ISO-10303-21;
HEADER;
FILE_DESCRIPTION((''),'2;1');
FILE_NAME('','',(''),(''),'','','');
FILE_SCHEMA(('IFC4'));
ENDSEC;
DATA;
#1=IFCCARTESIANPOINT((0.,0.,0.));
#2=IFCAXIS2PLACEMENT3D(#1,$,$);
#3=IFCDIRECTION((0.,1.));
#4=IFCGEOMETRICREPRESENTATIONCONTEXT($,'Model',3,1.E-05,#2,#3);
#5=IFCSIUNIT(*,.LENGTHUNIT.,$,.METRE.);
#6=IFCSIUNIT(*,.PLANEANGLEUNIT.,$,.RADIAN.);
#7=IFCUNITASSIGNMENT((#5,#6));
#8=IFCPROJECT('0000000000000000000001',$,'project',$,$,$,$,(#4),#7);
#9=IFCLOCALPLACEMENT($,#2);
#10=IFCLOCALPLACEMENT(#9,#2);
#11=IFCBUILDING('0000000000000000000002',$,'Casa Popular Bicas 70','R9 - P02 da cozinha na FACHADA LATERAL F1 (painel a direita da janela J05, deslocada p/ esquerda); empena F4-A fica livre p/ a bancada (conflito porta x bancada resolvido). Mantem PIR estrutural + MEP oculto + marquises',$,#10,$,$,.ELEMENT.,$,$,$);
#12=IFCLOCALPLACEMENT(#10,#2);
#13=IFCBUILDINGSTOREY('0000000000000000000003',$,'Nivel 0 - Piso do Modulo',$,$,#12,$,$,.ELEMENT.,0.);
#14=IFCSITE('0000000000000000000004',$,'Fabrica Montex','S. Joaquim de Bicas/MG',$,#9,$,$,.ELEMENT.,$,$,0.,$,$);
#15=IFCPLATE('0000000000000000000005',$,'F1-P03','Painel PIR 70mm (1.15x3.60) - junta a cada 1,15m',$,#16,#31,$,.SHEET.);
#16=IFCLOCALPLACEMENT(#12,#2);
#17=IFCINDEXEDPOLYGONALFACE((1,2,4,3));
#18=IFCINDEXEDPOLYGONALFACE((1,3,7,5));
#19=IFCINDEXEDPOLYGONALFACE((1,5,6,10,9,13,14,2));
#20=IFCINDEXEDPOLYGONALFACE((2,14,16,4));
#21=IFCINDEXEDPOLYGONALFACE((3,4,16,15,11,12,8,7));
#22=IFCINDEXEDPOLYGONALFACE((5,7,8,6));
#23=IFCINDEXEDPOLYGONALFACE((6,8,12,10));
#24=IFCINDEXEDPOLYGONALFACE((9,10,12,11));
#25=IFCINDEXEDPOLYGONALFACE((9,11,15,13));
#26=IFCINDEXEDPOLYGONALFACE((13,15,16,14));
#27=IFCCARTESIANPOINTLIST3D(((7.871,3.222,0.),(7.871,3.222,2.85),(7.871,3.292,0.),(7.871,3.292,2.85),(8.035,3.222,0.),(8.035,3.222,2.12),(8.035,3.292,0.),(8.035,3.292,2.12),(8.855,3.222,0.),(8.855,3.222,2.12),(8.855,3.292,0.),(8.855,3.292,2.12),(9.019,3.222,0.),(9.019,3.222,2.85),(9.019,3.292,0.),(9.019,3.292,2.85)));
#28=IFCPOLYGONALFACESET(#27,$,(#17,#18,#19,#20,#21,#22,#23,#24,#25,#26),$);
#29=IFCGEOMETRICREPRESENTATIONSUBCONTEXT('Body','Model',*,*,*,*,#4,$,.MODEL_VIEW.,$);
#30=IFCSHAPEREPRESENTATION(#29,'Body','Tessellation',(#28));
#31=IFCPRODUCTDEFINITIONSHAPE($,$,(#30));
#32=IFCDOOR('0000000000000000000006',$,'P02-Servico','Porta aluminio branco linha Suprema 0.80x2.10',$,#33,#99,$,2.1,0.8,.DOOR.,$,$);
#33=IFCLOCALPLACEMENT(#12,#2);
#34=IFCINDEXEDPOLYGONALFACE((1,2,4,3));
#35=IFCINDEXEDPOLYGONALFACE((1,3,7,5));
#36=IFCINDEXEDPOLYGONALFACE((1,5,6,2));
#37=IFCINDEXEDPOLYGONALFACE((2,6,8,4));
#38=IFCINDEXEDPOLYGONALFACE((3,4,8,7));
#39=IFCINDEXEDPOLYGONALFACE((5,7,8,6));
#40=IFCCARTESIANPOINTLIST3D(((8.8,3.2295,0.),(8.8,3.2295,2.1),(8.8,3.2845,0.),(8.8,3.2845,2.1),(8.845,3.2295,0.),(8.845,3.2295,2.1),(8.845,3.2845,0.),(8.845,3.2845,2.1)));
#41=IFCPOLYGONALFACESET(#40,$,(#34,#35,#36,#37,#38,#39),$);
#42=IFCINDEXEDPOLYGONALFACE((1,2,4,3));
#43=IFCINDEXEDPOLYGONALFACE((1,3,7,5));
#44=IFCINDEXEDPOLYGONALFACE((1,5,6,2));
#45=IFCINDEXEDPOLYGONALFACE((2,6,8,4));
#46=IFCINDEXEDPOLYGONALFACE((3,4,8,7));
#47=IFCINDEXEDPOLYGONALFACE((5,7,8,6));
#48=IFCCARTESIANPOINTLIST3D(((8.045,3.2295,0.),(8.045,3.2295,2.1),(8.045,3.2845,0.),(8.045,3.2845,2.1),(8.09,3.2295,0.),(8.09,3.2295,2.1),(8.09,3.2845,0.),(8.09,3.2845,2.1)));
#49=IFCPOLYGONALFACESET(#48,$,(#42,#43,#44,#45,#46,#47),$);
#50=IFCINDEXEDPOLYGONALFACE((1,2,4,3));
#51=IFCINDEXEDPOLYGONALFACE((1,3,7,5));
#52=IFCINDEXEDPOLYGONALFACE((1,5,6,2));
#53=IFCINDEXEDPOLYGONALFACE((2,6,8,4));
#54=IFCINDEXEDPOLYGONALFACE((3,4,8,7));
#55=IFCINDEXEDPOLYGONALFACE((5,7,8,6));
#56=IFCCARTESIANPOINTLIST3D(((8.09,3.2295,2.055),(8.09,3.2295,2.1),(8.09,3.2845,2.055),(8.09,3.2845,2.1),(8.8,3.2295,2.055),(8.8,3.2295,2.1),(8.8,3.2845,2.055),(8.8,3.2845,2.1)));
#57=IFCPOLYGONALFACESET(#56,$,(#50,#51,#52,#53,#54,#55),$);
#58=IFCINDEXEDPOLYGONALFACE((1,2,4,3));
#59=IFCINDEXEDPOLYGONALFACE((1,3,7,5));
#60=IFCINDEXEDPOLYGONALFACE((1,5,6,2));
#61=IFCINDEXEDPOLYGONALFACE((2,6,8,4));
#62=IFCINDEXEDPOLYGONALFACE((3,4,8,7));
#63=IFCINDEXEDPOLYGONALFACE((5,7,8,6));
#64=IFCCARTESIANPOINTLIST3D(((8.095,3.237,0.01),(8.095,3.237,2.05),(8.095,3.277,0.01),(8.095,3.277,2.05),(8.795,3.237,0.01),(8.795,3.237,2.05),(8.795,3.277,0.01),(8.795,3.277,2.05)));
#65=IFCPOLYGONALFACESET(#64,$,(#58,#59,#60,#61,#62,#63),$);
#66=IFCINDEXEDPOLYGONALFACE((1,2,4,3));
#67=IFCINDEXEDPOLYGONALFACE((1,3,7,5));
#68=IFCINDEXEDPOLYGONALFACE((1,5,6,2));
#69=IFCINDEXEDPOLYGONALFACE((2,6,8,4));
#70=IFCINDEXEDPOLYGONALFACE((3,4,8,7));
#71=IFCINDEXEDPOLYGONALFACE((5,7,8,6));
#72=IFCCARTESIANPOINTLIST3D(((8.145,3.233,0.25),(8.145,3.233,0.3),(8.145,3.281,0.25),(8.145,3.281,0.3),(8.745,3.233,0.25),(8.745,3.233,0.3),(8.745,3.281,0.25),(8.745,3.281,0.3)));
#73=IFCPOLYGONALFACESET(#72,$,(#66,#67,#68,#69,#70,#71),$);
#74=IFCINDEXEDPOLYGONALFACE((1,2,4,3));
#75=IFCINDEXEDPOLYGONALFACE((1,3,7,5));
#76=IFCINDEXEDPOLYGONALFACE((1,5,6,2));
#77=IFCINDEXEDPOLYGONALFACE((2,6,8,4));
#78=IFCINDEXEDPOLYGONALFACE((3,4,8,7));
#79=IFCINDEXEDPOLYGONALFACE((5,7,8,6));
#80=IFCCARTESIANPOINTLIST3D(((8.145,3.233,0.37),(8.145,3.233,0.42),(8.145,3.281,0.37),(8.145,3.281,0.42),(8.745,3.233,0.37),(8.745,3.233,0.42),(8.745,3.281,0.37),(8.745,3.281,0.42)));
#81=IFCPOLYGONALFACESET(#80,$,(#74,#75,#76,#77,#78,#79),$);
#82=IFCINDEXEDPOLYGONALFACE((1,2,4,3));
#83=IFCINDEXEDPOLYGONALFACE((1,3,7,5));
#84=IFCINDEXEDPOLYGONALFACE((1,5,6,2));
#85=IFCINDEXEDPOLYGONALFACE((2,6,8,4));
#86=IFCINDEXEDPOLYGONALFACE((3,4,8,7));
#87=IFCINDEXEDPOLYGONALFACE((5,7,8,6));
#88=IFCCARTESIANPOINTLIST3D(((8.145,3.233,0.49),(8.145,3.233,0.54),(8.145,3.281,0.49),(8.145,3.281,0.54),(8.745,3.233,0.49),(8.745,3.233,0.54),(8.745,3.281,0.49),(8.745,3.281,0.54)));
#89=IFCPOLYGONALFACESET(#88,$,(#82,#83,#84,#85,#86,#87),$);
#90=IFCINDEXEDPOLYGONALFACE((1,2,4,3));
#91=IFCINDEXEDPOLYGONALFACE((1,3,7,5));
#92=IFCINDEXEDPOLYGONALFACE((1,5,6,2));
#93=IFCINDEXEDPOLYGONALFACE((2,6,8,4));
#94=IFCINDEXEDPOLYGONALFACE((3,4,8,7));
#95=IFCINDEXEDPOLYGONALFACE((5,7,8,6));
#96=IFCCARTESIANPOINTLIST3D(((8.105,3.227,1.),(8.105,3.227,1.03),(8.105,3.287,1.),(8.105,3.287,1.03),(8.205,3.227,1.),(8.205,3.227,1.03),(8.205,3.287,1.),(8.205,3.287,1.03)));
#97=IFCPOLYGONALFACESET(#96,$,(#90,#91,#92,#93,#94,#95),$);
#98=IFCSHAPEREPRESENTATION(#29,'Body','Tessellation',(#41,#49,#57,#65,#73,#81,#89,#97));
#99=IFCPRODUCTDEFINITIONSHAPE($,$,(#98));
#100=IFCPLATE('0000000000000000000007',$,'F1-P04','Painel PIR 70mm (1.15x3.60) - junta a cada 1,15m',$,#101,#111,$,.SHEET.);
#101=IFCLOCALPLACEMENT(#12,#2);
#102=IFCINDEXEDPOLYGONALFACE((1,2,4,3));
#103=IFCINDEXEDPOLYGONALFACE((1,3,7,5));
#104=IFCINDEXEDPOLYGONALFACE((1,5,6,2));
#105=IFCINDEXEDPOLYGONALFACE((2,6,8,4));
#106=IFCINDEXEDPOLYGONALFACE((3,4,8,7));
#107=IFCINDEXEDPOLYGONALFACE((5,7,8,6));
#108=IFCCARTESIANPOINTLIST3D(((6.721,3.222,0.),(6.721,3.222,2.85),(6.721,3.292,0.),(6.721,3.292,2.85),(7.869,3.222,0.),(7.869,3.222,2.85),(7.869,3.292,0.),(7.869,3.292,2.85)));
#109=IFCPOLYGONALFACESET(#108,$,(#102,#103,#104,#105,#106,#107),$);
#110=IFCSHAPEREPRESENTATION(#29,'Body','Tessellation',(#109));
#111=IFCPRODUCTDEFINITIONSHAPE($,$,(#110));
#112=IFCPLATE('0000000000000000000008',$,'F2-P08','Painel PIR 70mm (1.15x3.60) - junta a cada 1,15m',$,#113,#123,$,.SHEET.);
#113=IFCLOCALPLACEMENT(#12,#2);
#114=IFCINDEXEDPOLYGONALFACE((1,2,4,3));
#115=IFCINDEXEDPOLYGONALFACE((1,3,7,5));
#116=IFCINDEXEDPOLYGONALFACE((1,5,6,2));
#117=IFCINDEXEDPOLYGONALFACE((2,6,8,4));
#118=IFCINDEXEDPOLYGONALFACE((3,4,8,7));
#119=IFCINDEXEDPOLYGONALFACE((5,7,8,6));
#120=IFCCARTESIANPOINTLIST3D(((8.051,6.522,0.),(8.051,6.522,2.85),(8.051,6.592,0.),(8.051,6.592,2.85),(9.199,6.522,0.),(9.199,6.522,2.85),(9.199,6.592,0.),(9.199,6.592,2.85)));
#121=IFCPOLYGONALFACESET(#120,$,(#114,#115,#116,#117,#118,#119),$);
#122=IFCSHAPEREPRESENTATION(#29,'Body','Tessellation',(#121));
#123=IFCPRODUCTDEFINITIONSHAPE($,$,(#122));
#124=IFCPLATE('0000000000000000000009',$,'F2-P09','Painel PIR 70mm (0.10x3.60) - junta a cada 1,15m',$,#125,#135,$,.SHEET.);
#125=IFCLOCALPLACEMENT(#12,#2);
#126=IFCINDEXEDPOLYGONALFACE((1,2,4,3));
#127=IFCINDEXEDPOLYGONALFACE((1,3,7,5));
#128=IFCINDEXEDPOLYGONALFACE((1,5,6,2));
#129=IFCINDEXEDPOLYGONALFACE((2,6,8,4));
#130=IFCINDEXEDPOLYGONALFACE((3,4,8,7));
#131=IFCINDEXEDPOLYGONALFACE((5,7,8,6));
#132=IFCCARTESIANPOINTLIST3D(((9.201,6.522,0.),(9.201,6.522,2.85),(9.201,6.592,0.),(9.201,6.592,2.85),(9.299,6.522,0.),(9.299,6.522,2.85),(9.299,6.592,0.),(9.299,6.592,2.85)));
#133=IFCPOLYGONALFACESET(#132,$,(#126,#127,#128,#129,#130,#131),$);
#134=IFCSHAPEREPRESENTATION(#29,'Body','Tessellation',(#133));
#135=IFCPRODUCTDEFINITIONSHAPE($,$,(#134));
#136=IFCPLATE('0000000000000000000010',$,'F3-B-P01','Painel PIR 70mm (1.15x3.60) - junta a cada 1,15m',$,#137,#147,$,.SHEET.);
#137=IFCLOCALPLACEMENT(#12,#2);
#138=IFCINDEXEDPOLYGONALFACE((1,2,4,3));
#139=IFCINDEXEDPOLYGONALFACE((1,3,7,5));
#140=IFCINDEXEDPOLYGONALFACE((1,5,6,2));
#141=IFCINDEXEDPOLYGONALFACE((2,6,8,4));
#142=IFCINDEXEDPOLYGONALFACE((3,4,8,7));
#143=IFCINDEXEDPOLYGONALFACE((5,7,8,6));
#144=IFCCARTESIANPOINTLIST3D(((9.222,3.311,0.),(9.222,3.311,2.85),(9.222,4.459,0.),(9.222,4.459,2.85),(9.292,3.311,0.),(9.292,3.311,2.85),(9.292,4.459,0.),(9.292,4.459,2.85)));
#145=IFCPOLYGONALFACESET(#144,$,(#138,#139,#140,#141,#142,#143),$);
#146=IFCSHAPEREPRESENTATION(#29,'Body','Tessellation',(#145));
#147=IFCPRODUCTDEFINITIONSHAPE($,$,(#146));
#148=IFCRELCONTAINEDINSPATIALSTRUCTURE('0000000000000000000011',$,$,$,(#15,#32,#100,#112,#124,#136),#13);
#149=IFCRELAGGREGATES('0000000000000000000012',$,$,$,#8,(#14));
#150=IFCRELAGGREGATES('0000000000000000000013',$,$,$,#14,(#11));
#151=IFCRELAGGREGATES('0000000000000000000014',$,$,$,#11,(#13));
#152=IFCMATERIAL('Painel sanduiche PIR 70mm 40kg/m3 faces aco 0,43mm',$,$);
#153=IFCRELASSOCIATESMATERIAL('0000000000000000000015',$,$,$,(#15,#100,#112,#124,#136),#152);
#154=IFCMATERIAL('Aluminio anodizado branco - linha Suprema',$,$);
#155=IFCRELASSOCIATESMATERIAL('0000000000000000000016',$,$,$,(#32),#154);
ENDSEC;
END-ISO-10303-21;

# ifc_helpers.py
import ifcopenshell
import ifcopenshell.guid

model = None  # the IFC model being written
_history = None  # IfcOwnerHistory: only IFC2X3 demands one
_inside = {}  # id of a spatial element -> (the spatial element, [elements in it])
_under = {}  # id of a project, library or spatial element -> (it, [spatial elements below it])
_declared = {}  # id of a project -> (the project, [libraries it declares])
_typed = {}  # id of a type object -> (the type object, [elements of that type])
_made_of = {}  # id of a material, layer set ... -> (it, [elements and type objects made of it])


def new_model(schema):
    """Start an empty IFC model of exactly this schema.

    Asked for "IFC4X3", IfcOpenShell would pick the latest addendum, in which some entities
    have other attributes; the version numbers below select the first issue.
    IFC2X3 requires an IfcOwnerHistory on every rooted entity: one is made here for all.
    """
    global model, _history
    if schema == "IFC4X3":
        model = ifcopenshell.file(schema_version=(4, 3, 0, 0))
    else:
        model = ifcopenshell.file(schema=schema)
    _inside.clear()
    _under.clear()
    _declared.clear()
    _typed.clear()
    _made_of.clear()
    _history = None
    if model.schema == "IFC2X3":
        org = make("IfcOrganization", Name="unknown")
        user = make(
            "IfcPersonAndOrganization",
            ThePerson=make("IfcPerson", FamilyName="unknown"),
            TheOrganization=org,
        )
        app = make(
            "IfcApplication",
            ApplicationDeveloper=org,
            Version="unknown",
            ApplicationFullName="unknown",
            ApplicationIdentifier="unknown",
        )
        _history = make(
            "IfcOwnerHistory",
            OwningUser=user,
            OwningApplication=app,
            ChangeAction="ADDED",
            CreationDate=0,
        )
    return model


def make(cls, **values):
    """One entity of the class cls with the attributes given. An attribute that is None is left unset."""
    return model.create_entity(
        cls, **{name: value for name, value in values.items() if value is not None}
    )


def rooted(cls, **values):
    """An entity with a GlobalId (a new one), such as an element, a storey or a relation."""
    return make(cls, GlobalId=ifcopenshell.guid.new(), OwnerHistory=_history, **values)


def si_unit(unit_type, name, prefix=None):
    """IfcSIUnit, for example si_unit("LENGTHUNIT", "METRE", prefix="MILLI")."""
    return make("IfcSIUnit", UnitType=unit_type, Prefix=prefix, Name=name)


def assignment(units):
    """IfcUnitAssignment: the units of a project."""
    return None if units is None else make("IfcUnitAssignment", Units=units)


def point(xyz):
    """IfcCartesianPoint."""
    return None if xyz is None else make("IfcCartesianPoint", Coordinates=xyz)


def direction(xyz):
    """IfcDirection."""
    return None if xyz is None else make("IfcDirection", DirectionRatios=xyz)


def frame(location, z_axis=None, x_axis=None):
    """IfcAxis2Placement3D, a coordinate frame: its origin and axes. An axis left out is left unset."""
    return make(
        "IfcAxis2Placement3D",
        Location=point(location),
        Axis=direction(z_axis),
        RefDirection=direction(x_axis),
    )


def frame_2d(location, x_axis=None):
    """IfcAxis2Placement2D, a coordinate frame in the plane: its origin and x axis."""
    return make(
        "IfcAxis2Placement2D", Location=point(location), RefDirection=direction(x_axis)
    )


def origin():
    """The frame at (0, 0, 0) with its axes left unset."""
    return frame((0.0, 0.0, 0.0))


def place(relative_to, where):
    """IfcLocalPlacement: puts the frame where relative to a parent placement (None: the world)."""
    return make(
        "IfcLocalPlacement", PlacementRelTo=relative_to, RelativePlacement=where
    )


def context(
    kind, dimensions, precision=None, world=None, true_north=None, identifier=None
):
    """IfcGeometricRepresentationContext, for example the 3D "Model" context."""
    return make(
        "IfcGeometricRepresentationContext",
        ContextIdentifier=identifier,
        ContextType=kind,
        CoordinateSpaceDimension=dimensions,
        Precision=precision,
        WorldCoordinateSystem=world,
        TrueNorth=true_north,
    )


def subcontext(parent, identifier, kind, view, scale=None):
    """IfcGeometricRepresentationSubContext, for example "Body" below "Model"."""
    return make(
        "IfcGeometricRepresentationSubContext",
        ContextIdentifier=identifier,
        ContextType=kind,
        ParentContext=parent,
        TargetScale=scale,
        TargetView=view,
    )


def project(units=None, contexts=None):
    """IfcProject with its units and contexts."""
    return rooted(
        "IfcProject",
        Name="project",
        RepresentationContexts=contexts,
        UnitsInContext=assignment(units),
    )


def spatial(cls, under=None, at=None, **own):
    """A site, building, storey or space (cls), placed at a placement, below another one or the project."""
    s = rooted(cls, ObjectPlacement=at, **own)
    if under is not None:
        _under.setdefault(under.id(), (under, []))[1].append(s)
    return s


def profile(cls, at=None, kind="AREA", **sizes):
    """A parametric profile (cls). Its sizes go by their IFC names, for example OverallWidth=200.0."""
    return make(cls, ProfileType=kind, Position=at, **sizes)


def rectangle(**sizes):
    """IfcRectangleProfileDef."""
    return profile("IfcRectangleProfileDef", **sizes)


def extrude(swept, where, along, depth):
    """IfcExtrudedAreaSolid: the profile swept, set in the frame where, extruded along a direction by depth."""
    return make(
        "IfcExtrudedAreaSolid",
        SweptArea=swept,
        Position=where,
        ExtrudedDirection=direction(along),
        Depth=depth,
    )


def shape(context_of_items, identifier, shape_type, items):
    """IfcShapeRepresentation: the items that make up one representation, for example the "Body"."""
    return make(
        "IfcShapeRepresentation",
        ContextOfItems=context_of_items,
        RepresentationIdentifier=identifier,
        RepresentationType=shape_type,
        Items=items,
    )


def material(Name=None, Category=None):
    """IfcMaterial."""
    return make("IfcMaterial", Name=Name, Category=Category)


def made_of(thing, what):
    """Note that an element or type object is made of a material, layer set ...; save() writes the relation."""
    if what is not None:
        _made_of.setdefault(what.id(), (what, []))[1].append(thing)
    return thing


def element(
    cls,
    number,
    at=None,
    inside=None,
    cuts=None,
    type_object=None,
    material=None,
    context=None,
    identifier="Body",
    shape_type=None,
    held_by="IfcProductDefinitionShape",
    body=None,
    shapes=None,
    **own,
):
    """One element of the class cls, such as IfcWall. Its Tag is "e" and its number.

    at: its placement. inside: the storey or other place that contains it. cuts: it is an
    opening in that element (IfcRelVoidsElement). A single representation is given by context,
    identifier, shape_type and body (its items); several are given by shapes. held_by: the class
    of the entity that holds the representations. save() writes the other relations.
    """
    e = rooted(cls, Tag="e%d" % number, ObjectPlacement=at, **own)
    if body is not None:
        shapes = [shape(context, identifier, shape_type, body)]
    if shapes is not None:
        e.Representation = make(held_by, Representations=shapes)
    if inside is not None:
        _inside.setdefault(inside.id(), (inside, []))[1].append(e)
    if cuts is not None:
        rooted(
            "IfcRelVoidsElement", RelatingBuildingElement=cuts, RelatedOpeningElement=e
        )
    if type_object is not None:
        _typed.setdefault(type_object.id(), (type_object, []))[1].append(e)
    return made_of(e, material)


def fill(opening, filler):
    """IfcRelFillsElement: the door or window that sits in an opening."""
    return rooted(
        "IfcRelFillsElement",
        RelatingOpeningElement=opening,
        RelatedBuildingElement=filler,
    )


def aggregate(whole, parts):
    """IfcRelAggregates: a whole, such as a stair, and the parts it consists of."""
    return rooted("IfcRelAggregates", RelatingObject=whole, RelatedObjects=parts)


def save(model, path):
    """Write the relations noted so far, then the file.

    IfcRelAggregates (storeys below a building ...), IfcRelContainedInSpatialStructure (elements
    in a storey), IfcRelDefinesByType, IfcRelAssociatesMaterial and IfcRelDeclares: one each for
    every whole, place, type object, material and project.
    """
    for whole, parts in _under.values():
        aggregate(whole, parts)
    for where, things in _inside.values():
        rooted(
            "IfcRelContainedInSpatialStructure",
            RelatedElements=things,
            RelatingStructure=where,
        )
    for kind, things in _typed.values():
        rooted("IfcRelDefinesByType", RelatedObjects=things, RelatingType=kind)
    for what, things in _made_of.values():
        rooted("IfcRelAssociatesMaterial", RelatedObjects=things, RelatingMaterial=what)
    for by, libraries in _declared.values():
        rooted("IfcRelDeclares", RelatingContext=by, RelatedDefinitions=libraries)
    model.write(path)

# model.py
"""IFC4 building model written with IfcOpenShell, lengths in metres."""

from ifc_helpers import new_model, si_unit, direction, frame, frame_2d, origin, place, context, subcontext, project, spatial, rectangle, extrude, material, element, fill, save


model = new_model("IFC4")

# Units and contexts
model_context = context("Model", 3, precision=1e-05, world=origin(), true_north=direction((0.0, 1.0)))
body_context = subcontext(model_context, "Body", "Model", "MODEL_VIEW")
ifc_project = project(units=[si_unit("LENGTHUNIT", "METRE"), si_unit("PLANEANGLEUNIT", "RADIAN")], contexts=[model_context])

# Site, building, storey
site_placement = place(None, origin())
site = spatial("IfcSite", under=ifc_project, at=site_placement, Name="Fabrica Montex", Description="S. Joaquim de Bicas/MG", CompositionType="ELEMENT", RefElevation=0.0)
building_placement = place(site_placement, origin())
building = spatial("IfcBuilding", under=site, at=building_placement, Name="Casa Popular Bicas 70", Description="R9 - P02 da cozinha na FACHADA LATERAL F1 (painel a direita da janela J05, deslocada p/ esquerda); empena F4-A fica livre p/ a bancada (conflito porta x bancada resolvido). Mantem PIR estrutural + MEP oculto + marquises", CompositionType="ELEMENT")
storey_placement = place(building_placement, origin())
storey = spatial("IfcBuildingStorey", under=building, at=storey_placement, Name="Nivel 0 - Piso do Modulo", CompositionType="ELEMENT", Elevation=0.0)

# Shared definitions
ifc_material_1 = material(Name="Aluminio anodizado branco - linha Suprema")

# Plate, opening, door
ifc_material_2 = material(Name="Painel sanduiche PIR 70mm 40kg/m3 faces aco 0,43mm")
plate_1_placement = place(None, frame((9.019, 3.257, 0.0), z_axis=(0.0, 0.0, 1.0), x_axis=(-1.0, 0.0, 0.0)))
plate_1 = element("IfcPlate", 1, at=plate_1_placement, inside=storey, material=ifc_material_2, Name="F1-P03", Description="Painel PIR 70mm (1.15x3.60) - junta a cada 1,15m", PredefinedType="SHEET", context=body_context, shape_type="SweptSolid", body=[
    extrude(rectangle(XDim=1.148, YDim=0.07, at=frame_2d((0.574, 0.0))), origin(), (0.0, 0.0, 1.0), 2.85),
])
opening_1_placement = place(None, frame((8.845, 3.257, 0.0), z_axis=(0.0, 0.0, 1.0), x_axis=(-1.0, 0.0, 0.0)))
opening_1 = element("IfcOpeningElement", 2, at=opening_1_placement, cuts=plate_1, PredefinedType="OPENING", context=body_context, shape_type="SweptSolid", body=[
    extrude(rectangle(XDim=0.82, YDim=0.3, at=frame_2d((0.4, 0.0))), origin(), (0.0, 0.0, 1.0), 2.12),
])
door_placement = place(None, frame((8.845, 3.257, 0.0), z_axis=(0.0, 0.0, 1.0), x_axis=(-1.0, 0.0, 0.0)))
door = element("IfcDoor", 3, at=door_placement, inside=storey, material=ifc_material_1, Name="P02-Servico", Description="Porta aluminio branco linha Suprema 0.80x2.10", OverallHeight=2.1, OverallWidth=0.8, PredefinedType="DOOR", context=body_context, shape_type="SweptSolid", body=[
    extrude(rectangle(XDim=0.045, YDim=0.055, at=frame_2d((0.0225, 0.0))), origin(), (0.0, 0.0, 1.0), 2.1),
    extrude(rectangle(XDim=0.045, YDim=0.055, at=frame_2d((0.7775, 0.0))), origin(), (0.0, 0.0, 1.0), 2.1),
    extrude(rectangle(XDim=0.71, YDim=0.055, at=frame_2d((0.4, 0.0))), frame((0.0, 0.0, 2.055)), (0.0, 0.0, 1.0), 0.045),
    extrude(rectangle(XDim=0.7, YDim=0.04, at=frame_2d((0.4, 0.0))), frame((0.0, 0.0, 0.01)), (0.0, 0.0, 1.0), 2.04),
    extrude(rectangle(XDim=0.6, YDim=0.048, at=frame_2d((0.4, 0.0))), frame((0.0, 0.0, 0.25)), (0.0, 0.0, 1.0), 0.05),
    extrude(rectangle(XDim=0.6, YDim=0.048, at=frame_2d((0.4, 0.0))), frame((0.0, 0.0, 0.37)), (0.0, 0.0, 1.0), 0.05),
    extrude(rectangle(XDim=0.6, YDim=0.048, at=frame_2d((0.4, 0.0))), frame((0.0, 0.0, 0.49)), (0.0, 0.0, 1.0), 0.05),
    extrude(rectangle(XDim=0.1, YDim=0.06, at=frame_2d((0.69, 0.0))), frame((0.0, 0.0, 1.0)), (0.0, 0.0, 1.0), 0.03),
])
fill(opening_1, door)

# Plates
plate_2_placement = place(None, frame((7.869, 3.257, 0.0), z_axis=(0.0, 0.0, 1.0), x_axis=(-1.0, 0.0, 0.0)))
element("IfcPlate", 4, at=plate_2_placement, inside=storey, material=ifc_material_2, Name="F1-P04", Description="Painel PIR 70mm (1.15x3.60) - junta a cada 1,15m", PredefinedType="SHEET", context=body_context, shape_type="SweptSolid", body=[
    extrude(rectangle(XDim=1.148, YDim=0.07, at=frame_2d((0.574, 0.0))), origin(), (0.0, 0.0, 1.0), 2.85),
])
plate_3_placement = place(storey_placement, frame((8.051, 6.557, 0.0), x_axis=(1.0, 0.0, 0.0)))
element("IfcPlate", 5, at=plate_3_placement, inside=storey, material=ifc_material_2, Name="F2-P08", Description="Painel PIR 70mm (1.15x3.60) - junta a cada 1,15m", PredefinedType="SHEET", context=body_context, shape_type="SweptSolid", body=[
    extrude(rectangle(XDim=1.148, YDim=0.07, at=frame_2d((0.574, 0.0))), origin(), (0.0, 0.0, 1.0), 2.85),
])
plate_4_placement = place(storey_placement, frame((9.201, 6.557, 0.0), x_axis=(1.0, 0.0, 0.0)))
element("IfcPlate", 6, at=plate_4_placement, inside=storey, material=ifc_material_2, Name="F2-P09", Description="Painel PIR 70mm (0.10x3.60) - junta a cada 1,15m", PredefinedType="SHEET", context=body_context, shape_type="SweptSolid", body=[
    extrude(rectangle(XDim=0.098, YDim=0.07, at=frame_2d((0.049, 0.0))), origin(), (0.0, 0.0, 1.0), 2.85),
])
plate_5_placement = place(storey_placement, frame((9.257, 3.311, 0.0), x_axis=(0.0, 1.0, 0.0)))
element("IfcPlate", 7, at=plate_5_placement, inside=storey, material=ifc_material_2, Name="F3-B-P01", Description="Painel PIR 70mm (1.15x3.60) - junta a cada 1,15m", PredefinedType="SHEET", context=body_context, shape_type="SweptSolid", body=[
    extrude(rectangle(XDim=1.148, YDim=0.07, at=frame_2d((0.574, 0.0))), origin(), (0.0, 0.0, 1.0), 2.85),
])

save(model, "model.ifc")
